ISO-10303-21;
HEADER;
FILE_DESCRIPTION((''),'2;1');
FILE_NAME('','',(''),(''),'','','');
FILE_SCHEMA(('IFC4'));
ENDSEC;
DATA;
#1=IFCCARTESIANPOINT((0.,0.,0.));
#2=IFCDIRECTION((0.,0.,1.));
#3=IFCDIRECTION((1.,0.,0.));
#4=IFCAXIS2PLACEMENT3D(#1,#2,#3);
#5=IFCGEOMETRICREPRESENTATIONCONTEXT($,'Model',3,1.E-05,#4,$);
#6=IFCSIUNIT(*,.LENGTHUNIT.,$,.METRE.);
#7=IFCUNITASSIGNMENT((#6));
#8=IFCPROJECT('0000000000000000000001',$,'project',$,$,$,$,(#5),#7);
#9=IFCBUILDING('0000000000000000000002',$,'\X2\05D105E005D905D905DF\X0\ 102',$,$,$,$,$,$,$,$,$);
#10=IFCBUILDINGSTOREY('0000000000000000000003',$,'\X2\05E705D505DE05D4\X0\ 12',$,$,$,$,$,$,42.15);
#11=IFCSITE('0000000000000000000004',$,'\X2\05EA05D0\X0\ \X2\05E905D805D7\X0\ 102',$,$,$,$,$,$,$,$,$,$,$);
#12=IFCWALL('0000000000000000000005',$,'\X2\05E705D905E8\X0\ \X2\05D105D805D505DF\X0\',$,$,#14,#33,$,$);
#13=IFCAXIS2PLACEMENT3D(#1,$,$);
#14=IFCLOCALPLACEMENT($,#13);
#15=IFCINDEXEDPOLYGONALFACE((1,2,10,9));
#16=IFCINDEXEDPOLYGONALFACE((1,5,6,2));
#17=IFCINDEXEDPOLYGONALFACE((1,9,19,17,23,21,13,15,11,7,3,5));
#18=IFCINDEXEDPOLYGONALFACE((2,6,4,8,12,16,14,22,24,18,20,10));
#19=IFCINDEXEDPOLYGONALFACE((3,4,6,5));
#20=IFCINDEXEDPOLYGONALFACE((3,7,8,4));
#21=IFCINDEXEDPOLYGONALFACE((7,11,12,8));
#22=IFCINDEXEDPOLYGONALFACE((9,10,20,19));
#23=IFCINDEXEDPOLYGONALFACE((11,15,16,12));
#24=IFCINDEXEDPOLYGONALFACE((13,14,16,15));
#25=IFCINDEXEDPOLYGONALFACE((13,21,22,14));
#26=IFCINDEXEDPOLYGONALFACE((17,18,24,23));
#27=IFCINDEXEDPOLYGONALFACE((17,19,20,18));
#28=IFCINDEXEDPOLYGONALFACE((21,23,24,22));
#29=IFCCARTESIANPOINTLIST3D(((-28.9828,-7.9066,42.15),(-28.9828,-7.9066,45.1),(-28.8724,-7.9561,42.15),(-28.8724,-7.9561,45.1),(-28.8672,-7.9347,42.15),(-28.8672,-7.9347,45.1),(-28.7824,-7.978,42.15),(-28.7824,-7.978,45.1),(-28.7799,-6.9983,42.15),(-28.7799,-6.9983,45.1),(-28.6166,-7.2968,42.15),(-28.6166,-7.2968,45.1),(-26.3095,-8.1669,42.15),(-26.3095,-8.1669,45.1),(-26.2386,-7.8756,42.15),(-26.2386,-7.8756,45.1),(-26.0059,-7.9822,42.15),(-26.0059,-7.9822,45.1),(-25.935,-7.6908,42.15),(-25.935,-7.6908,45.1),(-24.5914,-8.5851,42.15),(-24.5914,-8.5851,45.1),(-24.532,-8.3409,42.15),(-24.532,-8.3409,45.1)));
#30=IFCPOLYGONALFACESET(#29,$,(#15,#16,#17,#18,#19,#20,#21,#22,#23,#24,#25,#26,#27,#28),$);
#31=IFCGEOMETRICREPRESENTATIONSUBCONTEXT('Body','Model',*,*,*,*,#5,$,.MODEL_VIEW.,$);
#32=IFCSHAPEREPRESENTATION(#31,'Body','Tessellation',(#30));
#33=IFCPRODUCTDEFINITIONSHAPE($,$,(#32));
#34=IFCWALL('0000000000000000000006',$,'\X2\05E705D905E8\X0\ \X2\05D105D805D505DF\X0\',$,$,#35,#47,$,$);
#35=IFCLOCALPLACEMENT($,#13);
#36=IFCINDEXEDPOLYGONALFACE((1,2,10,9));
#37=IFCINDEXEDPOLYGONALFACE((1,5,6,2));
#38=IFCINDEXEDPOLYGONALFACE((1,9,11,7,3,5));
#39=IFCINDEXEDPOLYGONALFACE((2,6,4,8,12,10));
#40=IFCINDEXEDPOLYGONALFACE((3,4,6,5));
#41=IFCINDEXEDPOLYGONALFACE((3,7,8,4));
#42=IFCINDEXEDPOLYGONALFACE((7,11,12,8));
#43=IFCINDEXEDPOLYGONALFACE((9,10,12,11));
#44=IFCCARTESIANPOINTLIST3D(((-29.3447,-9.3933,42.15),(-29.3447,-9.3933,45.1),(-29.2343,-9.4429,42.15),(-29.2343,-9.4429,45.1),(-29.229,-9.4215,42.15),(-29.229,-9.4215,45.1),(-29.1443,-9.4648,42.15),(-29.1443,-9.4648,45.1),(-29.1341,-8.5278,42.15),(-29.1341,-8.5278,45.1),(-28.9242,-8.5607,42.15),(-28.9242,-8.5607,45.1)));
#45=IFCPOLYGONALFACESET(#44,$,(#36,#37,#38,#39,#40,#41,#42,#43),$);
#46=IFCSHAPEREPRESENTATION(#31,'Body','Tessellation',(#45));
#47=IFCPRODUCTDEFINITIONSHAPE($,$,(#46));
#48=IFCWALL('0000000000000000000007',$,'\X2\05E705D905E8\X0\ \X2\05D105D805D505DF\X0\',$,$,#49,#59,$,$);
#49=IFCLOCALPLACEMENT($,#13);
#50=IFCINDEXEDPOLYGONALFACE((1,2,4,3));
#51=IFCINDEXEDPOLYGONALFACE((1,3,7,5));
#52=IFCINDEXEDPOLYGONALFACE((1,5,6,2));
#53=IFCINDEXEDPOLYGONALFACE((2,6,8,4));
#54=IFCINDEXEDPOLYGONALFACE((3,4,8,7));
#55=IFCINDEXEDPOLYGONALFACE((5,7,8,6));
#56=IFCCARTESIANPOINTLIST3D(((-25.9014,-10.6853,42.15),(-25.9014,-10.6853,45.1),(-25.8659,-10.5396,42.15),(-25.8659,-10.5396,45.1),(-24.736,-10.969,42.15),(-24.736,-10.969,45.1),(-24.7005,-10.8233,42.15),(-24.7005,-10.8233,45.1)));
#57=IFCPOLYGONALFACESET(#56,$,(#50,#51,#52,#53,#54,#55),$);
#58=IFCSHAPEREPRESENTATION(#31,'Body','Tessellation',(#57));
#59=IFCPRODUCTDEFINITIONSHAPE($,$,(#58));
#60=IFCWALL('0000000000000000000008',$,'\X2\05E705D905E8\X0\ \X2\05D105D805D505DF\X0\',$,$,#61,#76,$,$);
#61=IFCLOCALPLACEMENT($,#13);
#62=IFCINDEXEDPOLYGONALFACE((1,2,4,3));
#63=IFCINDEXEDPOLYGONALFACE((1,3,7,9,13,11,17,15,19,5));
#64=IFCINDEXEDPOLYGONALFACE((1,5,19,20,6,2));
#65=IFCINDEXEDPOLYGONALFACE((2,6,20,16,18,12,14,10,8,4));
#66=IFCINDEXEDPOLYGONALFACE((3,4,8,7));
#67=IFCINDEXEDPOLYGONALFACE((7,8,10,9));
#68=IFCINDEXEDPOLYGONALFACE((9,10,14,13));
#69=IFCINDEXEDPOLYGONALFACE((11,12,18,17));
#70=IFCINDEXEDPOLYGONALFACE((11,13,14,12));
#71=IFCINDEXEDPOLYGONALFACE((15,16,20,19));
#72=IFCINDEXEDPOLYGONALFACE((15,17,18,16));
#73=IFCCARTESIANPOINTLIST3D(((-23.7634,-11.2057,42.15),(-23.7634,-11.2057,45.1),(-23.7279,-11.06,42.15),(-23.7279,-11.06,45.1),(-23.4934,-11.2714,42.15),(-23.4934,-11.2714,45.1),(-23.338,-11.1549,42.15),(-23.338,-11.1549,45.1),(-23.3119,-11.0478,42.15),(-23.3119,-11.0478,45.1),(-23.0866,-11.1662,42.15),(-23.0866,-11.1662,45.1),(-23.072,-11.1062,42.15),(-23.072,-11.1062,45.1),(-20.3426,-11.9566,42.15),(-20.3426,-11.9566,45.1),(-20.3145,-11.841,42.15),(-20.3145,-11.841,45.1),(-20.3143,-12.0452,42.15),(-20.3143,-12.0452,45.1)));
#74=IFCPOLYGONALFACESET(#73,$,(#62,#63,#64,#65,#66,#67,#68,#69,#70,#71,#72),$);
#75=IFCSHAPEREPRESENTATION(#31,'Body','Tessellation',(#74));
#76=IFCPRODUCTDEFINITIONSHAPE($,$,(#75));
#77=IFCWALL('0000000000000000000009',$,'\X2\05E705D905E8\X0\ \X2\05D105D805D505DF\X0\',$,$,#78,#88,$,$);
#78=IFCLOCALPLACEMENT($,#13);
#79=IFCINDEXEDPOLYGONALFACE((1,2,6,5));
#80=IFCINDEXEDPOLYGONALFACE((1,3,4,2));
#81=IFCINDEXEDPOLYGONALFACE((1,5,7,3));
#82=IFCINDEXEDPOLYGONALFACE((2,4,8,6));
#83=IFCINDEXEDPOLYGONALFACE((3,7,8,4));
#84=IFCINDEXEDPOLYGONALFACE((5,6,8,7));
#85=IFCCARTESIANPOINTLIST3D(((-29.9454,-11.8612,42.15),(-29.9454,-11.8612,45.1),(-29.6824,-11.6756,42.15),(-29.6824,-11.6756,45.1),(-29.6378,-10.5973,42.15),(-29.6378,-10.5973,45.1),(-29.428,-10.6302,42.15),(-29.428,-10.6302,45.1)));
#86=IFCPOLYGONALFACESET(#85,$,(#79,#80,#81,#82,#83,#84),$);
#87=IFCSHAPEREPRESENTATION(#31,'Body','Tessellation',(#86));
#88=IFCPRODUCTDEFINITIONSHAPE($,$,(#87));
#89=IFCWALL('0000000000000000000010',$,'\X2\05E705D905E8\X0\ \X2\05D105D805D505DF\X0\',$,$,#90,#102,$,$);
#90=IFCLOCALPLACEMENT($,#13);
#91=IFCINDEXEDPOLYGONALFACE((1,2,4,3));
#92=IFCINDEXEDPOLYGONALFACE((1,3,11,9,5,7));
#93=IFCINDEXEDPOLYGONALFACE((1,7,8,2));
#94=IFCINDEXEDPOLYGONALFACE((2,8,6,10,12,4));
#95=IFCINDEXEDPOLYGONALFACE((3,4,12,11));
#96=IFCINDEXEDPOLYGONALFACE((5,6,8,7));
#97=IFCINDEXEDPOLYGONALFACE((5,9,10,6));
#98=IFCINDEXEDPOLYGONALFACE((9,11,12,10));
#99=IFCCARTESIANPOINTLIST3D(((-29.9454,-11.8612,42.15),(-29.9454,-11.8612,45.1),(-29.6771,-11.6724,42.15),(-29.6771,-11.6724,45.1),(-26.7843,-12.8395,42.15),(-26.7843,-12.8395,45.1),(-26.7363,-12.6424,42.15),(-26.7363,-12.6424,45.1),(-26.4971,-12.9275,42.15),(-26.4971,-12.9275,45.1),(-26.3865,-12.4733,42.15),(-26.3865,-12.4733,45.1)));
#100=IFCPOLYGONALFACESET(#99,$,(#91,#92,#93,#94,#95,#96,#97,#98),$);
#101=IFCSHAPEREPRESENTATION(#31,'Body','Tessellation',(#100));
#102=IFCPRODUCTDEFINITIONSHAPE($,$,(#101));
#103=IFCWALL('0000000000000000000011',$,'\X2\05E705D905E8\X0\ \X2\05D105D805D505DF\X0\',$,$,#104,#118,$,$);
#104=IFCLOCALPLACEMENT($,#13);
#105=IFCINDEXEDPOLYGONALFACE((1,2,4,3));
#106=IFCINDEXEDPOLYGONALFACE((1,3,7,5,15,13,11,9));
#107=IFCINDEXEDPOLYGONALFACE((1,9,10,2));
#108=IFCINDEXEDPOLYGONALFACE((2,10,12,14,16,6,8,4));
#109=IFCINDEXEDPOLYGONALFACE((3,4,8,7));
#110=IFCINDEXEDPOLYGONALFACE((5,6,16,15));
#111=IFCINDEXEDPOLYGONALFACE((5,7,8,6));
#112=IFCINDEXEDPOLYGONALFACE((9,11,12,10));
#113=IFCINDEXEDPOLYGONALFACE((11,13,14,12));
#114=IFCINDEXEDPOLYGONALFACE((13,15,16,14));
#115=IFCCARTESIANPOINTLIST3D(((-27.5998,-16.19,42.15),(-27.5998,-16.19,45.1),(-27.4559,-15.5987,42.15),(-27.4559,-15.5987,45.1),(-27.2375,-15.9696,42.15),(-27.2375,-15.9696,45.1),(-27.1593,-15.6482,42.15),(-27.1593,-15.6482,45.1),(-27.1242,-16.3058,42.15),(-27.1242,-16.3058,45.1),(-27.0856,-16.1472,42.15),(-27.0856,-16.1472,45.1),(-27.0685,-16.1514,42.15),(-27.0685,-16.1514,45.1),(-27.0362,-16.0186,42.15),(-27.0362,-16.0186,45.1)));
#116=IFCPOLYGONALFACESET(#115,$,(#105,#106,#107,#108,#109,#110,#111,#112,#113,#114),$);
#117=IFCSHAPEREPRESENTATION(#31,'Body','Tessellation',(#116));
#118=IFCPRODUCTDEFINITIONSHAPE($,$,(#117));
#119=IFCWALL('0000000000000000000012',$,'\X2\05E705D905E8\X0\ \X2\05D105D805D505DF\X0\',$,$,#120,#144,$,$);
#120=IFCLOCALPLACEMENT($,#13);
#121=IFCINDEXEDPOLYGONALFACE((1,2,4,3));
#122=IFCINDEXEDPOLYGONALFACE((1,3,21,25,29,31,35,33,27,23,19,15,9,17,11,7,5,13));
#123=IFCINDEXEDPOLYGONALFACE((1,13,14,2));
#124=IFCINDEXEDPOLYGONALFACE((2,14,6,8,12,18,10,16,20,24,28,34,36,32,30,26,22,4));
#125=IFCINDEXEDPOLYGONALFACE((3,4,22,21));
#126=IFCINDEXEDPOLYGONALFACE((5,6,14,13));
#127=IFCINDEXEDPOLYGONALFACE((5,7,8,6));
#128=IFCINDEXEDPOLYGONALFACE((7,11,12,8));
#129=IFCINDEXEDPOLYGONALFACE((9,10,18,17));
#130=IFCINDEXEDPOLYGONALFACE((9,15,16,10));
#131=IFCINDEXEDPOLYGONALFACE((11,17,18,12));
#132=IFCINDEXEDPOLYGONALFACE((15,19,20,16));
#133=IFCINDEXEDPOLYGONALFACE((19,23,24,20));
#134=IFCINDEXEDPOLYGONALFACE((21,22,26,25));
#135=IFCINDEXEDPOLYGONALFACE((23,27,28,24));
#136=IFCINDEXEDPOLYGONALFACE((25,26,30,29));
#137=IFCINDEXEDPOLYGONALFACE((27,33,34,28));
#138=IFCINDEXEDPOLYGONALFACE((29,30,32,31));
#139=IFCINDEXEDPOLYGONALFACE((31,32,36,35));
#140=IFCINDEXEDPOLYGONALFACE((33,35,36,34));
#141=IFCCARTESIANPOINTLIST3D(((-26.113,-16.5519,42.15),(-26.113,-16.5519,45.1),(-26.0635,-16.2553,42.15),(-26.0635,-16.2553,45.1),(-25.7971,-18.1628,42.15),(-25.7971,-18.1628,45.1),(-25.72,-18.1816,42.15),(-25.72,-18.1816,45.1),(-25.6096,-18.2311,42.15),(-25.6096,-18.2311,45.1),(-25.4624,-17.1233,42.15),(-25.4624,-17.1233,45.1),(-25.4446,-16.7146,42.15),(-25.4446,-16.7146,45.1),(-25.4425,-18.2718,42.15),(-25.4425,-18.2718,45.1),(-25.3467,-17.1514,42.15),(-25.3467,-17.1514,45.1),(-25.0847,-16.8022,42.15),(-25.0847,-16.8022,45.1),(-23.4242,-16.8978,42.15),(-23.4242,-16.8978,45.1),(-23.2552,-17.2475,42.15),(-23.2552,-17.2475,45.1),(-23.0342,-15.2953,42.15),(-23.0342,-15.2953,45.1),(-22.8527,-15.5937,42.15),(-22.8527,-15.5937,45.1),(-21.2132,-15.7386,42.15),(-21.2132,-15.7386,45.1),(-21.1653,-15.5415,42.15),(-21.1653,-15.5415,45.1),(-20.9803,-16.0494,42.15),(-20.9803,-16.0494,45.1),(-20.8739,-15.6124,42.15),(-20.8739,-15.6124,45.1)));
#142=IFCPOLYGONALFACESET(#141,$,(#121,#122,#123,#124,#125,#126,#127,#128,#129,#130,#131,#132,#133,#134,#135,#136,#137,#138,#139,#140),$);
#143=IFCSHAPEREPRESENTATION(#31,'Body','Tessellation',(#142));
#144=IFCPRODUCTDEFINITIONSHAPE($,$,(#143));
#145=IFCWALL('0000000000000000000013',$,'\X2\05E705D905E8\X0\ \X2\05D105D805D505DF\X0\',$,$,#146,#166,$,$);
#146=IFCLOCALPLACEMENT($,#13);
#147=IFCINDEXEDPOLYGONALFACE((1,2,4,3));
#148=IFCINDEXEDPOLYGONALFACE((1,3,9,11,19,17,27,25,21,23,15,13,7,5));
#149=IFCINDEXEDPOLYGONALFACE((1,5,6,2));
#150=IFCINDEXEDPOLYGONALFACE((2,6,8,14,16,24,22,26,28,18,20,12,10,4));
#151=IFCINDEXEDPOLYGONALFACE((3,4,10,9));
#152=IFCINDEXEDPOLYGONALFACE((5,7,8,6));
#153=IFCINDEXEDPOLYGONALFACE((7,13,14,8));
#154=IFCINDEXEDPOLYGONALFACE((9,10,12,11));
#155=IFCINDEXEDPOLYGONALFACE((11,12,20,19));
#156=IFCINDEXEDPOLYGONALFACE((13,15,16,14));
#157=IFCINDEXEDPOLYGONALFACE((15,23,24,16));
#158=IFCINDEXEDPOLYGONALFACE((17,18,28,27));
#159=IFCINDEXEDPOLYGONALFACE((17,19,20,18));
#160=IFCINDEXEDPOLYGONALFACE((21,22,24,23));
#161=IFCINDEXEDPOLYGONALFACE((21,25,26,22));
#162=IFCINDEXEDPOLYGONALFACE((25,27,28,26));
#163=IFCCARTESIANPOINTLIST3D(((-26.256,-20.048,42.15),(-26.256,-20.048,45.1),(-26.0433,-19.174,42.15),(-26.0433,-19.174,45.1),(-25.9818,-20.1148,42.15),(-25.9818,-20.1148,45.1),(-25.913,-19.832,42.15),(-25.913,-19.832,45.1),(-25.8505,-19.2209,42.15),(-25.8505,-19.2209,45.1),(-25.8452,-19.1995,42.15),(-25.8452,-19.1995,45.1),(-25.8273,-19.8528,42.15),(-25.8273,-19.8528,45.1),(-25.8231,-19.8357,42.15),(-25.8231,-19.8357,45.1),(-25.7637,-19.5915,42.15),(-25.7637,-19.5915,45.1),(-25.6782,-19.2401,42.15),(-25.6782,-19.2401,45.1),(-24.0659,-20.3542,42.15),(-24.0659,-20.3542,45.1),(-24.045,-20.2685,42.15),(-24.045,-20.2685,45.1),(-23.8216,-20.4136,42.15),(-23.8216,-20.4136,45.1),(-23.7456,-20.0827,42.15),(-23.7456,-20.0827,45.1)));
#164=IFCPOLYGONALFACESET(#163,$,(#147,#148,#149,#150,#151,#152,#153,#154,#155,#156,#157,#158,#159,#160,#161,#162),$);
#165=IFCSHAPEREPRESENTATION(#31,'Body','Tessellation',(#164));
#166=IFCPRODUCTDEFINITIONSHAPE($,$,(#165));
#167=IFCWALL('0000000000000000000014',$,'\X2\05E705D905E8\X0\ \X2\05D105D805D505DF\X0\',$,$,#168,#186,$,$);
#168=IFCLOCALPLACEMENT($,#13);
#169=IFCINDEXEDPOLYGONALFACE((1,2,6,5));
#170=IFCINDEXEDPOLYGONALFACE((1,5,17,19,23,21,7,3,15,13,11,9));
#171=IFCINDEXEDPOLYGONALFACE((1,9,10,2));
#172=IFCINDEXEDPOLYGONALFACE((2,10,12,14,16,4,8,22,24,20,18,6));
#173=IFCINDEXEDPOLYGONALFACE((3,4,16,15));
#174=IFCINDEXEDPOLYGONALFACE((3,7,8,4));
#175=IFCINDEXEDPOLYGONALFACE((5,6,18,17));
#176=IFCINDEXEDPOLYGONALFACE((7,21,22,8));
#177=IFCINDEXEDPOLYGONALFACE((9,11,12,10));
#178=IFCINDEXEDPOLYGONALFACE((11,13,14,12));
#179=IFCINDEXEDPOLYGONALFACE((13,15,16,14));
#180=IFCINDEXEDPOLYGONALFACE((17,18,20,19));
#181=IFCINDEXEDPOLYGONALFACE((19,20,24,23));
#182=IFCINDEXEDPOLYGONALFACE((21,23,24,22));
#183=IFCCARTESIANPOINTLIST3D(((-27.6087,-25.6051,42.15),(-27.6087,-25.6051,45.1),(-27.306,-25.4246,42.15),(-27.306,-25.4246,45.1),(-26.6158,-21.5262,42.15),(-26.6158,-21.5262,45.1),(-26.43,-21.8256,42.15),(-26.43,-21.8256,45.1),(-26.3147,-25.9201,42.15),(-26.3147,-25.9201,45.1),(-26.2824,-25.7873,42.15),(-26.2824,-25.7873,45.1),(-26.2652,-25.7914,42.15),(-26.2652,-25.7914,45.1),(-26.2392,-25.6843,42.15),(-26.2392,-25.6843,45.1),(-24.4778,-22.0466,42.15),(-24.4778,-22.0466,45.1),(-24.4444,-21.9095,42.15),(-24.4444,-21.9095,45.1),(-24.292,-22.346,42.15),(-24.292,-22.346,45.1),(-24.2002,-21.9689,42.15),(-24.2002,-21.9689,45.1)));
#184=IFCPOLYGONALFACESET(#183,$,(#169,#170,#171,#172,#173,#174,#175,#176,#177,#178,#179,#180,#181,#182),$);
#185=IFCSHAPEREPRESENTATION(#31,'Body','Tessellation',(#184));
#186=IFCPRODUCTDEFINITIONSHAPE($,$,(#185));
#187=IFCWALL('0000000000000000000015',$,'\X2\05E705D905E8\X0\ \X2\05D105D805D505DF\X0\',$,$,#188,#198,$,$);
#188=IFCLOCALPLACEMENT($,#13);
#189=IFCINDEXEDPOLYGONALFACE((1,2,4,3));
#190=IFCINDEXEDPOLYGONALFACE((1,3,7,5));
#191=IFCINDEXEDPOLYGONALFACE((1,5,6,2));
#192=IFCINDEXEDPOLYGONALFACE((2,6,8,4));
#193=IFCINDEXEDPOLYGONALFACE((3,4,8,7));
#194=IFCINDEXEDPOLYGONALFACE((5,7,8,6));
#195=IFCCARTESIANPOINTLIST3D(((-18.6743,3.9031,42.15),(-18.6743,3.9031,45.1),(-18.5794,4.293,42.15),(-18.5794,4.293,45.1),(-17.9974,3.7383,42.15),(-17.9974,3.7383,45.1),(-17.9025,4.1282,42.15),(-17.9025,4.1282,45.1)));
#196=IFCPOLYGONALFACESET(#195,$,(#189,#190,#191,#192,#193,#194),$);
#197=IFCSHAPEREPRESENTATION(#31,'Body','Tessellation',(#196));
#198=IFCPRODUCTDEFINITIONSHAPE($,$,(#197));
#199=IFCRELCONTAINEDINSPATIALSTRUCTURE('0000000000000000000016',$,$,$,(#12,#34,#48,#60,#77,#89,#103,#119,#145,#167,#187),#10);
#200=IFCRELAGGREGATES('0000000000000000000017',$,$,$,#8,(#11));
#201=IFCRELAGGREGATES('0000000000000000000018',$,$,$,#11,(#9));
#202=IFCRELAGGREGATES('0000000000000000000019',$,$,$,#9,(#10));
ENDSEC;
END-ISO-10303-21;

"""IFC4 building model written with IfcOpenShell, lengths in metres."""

from ifc_helpers import new_model, si_unit, frame, origin_with_axes, context, subcontext, project, spatial, polyline, outline, extrude, element, save


model = new_model("IFC4")

# Units and contexts
model_context = context("Model", 3, precision=1e-05, world=origin_with_axes())
body_context = subcontext(model_context, "Body", "Model", "MODEL_VIEW")
ifc_project = project(units=[si_unit("LENGTHUNIT", "METRE")], contexts=[model_context])

# Site, building, storey
site = spatial("IfcSite", under=ifc_project, Name="תא שטח 102")
building = spatial("IfcBuilding", under=site, Name="בניין 102")
storey = spatial("IfcBuildingStorey", under=building, Name="קומה 12", Elevation=42.15)

# Walls
element("IfcWall", 1, inside=storey, Name="קיר בטון", context=body_context, shape_type="SweptSolid", body=[
    extrude(outline(polyline([(-28.8672, -7.9347), (-28.8724, -7.9561), (-28.7824, -7.978), (-28.6166, -7.2968), (-26.2386, -7.8756), (-26.3095, -8.1669), (-24.5914, -8.5851), (-24.532, -8.3409), (-26.0059, -7.9822), (-25.935, -7.6908), (-28.7799, -6.9983), (-28.9828, -7.9066), (-28.8672, -7.9347)])), frame((0.0, 0.0, 42.15)), (0.0, 0.0, 1.0), 2.95),
])
element("IfcWall", 2, inside=storey, Name="קיר בטון", context=body_context, shape_type="SweptSolid", body=[
    extrude(outline(polyline([(-29.229, -9.4215), (-29.2343, -9.4429), (-29.1443, -9.4648), (-28.9242, -8.5607), (-29.1341, -8.5278), (-29.3447, -9.3933), (-29.229, -9.4215)])), frame((0.0, 0.0, 42.15)), (0.0, 0.0, 1.0), 2.95),
])
element("IfcWall", 3, inside=storey, Name="קיר בטון", context=body_context, shape_type="SweptSolid", body=[
    extrude(outline(polyline([(-25.8659, -10.5396), (-25.9014, -10.6853), (-24.736, -10.969), (-24.7005, -10.8233), (-25.8659, -10.5396)])), frame((0.0, 0.0, 42.15)), (0.0, 0.0, 1.0), 2.95),
])
element("IfcWall", 4, inside=storey, Name="קיר בטון", context=body_context, shape_type="SweptSolid", body=[
    extrude(outline(polyline([(-23.7634, -11.2057), (-23.4934, -11.2714), (-20.3143, -12.0452), (-20.3426, -11.9566), (-20.3145, -11.841), (-23.0866, -11.1662), (-23.072, -11.1062), (-23.3119, -11.0478), (-23.338, -11.1549), (-23.7279, -11.06), (-23.7634, -11.2057)])), frame((0.0, 0.0, 42.15)), (0.0, 0.0, 1.0), 2.95),
])
element("IfcWall", 5, inside=storey, Name="קיר בטון", context=body_context, shape_type="SweptSolid", body=[
    extrude(outline(polyline([(-29.9454, -11.8612), (-29.6824, -11.6756), (-29.428, -10.6302), (-29.6378, -10.5973), (-29.9454, -11.8612)])), frame((0.0, 0.0, 42.15)), (0.0, 0.0, 1.0), 2.95),
])
element("IfcWall", 6, inside=storey, Name="קיר בטון", context=body_context, shape_type="SweptSolid", body=[
    extrude(outline(polyline([(-26.7843, -12.8395), (-26.4971, -12.9275), (-26.3865, -12.4733), (-29.6771, -11.6724), (-29.9454, -11.8612), (-26.7363, -12.6424), (-26.7843, -12.8395)])), frame((0.0, 0.0, 42.15)), (0.0, 0.0, 1.0), 2.95),
])
element("IfcWall", 7, inside=storey, Name="קיר בטון", context=body_context, shape_type="SweptSolid", body=[
    extrude(outline(polyline([(-27.0856, -16.1472), (-27.0685, -16.1514), (-27.0362, -16.0186), (-27.2375, -15.9696), (-27.1593, -15.6482), (-27.4559, -15.5987), (-27.5998, -16.19), (-27.1242, -16.3058), (-27.0856, -16.1472)])), frame((0.0, 0.0, 42.15)), (0.0, 0.0, 1.0), 2.95),
])
element("IfcWall", 8, inside=storey, Name="קיר בטון", context=body_context, shape_type="SweptSolid", body=[
    extrude(outline(polyline([(-25.6096, -18.2311), (-25.4425, -18.2718), (-25.0847, -16.8022), (-23.2552, -17.2475), (-22.8527, -15.5937), (-20.9803, -16.0494), (-20.8739, -15.6124), (-21.1653, -15.5415), (-21.2132, -15.7386), (-23.0342, -15.2953), (-23.4242, -16.8978), (-26.0635, -16.2553), (-26.113, -16.5519), (-25.4446, -16.7146), (-25.7971, -18.1628), (-25.72, -18.1816), (-25.4624, -17.1233), (-25.3467, -17.1514), (-25.6096, -18.2311)])), frame((0.0, 0.0, 42.15)), (0.0, 0.0, 1.0), 2.95),
])
element("IfcWall", 9, inside=storey, Name="קיר בטון", context=body_context, shape_type="SweptSolid", body=[
    extrude(outline(polyline([(-25.8505, -19.2209), (-26.0433, -19.174), (-26.256, -20.048), (-25.9818, -20.1148), (-25.913, -19.832), (-25.8273, -19.8528), (-25.8231, -19.8357), (-24.045, -20.2685), (-24.0659, -20.3542), (-23.8216, -20.4136), (-23.7456, -20.0827), (-25.7637, -19.5915), (-25.6782, -19.2401), (-25.8452, -19.1995), (-25.8505, -19.2209)])), frame((0.0, 0.0, 42.15)), (0.0, 0.0, 1.0), 2.95),
])
element("IfcWall", 10, inside=storey, Name="קיר בטון", context=body_context, shape_type="SweptSolid", body=[
    extrude(outline(polyline([(-27.6087, -25.6051), (-26.3147, -25.9201), (-26.2824, -25.7873), (-26.2652, -25.7914), (-26.2392, -25.6843), (-27.306, -25.4246), (-26.43, -21.8256), (-24.292, -22.346), (-24.2002, -21.9689), (-24.4444, -21.9095), (-24.4778, -22.0466), (-26.6158, -21.5262), (-27.6087, -25.6051)])), frame((0.0, 0.0, 42.15)), (0.0, 0.0, 1.0), 2.95),
])
element("IfcWall", 11, inside=storey, Name="קיר בטון", context=body_context, shape_type="SweptSolid", body=[
    extrude(outline(polyline([(-17.9974, 3.7383), (-17.9025, 4.1282), (-18.5794, 4.293), (-18.6743, 3.9031), (-17.9974, 3.7383)])), frame((0.0, 0.0, 42.15)), (0.0, 0.0, 1.0), 2.95),
])

save(model, "model.ifc")
